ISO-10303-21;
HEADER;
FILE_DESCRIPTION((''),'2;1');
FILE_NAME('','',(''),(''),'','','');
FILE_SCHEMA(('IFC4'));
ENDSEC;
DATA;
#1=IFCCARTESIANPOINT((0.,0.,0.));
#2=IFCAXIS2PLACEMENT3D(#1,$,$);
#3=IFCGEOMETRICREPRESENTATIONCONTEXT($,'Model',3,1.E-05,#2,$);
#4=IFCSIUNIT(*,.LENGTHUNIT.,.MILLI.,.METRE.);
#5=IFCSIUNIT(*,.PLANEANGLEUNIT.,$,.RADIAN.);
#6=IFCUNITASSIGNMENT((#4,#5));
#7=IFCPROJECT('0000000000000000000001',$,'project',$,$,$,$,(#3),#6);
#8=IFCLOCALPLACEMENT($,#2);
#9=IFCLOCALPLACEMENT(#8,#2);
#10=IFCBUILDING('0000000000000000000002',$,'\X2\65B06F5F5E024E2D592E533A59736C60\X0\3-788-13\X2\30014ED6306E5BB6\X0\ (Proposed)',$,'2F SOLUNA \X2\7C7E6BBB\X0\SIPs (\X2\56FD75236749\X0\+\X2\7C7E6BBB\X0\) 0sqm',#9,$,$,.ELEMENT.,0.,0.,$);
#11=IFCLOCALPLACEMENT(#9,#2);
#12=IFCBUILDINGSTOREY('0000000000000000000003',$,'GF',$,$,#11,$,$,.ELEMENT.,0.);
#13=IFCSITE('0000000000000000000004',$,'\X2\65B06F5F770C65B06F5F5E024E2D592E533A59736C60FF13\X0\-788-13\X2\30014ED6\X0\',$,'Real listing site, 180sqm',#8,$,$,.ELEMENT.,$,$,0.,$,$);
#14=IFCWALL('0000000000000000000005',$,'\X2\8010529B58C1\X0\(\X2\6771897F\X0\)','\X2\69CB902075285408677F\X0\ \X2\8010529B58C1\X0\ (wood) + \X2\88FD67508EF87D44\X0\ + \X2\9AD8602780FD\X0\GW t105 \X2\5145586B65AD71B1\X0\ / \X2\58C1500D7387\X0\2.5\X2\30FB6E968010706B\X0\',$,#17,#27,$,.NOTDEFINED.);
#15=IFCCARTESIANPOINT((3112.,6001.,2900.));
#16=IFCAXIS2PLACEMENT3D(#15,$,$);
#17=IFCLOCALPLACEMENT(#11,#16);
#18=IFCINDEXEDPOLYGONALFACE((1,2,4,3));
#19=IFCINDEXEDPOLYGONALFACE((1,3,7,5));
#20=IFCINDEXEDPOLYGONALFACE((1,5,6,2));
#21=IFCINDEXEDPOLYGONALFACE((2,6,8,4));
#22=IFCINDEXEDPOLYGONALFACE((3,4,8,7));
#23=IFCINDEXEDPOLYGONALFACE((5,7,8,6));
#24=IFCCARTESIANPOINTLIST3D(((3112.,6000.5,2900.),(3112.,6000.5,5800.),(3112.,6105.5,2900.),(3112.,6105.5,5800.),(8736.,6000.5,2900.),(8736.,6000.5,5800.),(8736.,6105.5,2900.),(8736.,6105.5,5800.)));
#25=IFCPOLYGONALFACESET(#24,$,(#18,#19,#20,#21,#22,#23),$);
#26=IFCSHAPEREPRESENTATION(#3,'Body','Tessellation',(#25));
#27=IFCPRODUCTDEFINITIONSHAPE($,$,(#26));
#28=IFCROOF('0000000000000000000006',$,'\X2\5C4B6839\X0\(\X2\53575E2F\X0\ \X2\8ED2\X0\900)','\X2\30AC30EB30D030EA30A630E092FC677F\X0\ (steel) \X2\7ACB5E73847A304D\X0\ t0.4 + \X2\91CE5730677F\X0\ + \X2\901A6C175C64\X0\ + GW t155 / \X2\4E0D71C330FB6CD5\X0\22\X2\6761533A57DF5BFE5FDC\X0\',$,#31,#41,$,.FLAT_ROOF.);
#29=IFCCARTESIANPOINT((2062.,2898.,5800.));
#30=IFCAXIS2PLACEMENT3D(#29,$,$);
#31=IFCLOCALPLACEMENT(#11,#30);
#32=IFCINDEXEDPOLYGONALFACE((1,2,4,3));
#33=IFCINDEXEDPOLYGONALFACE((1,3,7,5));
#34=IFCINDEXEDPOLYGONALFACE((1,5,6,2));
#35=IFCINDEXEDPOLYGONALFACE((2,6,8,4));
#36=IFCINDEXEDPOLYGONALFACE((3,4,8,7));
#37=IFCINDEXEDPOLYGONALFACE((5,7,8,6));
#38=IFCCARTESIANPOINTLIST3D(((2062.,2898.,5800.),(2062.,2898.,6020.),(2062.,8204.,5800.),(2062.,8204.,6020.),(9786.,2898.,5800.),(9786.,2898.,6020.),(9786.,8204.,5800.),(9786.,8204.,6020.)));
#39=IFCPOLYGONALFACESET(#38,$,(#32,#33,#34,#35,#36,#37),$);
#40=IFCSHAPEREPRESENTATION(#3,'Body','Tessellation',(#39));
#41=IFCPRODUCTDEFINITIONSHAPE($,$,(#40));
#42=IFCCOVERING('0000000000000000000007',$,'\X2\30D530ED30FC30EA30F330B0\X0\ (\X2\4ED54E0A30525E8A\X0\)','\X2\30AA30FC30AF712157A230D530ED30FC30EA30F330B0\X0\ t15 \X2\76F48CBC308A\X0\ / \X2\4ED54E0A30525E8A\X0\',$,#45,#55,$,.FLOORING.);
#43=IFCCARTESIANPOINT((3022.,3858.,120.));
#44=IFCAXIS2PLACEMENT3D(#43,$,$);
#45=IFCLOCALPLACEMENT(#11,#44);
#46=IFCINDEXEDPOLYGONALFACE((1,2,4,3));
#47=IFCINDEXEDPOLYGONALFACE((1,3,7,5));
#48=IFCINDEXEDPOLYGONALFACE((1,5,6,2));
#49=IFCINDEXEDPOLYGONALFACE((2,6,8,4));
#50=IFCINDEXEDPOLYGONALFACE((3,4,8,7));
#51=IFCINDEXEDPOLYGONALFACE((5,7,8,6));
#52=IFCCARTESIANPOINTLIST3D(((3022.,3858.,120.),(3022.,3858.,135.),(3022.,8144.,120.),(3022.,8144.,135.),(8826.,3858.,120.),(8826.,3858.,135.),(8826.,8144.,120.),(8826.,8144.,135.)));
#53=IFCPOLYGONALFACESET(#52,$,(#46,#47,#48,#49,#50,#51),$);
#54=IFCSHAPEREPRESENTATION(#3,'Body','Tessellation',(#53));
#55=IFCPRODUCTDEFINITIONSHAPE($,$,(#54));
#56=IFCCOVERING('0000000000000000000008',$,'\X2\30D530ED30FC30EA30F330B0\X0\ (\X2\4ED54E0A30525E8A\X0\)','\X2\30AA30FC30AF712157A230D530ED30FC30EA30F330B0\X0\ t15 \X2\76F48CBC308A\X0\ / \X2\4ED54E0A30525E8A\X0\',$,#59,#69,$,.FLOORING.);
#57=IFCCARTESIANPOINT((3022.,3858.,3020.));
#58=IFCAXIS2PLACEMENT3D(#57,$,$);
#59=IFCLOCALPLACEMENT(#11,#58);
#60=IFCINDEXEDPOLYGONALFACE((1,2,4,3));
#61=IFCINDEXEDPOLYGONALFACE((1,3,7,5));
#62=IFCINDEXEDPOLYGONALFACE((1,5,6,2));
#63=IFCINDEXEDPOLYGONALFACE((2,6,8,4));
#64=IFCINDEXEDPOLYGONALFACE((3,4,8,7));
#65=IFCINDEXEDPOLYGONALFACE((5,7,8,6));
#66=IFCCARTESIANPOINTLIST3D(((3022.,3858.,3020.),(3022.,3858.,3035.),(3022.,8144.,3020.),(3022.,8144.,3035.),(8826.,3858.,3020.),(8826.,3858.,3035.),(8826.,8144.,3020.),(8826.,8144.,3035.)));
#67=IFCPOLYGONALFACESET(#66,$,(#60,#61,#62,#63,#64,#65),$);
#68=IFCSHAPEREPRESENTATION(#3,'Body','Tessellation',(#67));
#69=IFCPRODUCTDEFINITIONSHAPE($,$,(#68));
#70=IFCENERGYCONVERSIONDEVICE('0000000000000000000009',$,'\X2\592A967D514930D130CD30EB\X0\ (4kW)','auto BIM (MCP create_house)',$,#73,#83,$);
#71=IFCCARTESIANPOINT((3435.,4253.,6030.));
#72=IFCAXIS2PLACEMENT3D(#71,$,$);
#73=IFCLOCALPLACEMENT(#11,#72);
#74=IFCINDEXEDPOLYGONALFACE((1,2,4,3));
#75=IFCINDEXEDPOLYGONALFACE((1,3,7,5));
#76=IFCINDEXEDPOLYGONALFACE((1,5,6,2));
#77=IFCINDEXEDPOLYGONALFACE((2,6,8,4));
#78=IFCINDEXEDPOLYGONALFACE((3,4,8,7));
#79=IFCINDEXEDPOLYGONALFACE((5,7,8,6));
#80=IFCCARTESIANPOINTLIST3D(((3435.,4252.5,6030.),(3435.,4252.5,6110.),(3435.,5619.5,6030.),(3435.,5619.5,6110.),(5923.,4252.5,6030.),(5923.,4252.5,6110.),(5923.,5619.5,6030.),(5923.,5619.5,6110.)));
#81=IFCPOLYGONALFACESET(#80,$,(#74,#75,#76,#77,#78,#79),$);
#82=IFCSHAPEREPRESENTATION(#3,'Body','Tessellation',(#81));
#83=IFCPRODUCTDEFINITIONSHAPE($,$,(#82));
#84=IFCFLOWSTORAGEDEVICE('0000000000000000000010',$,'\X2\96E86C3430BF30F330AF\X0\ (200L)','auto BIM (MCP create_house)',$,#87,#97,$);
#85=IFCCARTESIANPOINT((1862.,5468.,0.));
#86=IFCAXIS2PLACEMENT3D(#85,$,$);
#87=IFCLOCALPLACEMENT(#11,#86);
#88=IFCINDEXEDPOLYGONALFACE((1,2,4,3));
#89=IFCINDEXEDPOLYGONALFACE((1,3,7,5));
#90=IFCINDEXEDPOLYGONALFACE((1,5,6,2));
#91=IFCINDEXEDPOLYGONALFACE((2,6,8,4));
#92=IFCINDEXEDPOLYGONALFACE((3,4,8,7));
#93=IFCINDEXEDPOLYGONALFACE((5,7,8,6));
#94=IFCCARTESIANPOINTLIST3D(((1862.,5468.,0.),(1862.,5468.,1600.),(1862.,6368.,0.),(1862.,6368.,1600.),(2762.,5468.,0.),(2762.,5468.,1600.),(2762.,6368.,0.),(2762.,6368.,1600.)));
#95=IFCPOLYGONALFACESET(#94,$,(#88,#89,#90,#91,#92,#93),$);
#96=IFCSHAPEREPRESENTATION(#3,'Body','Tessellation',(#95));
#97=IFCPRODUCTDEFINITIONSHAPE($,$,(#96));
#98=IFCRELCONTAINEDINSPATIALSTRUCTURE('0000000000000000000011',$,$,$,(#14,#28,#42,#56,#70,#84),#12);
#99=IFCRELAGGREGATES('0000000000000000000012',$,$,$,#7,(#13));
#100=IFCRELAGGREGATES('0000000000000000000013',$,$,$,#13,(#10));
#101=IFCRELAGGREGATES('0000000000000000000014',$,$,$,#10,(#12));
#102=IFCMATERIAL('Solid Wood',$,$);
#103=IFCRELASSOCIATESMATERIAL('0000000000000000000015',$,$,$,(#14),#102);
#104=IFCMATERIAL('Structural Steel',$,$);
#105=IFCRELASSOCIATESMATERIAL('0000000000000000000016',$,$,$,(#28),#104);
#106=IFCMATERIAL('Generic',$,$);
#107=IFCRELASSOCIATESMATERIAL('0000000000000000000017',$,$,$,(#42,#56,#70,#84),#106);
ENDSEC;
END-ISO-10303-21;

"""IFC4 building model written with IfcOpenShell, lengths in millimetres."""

from ifc_helpers import new_model, si_unit, frame, frame_2d, origin, place, context, project, spatial, rectangle, extrude, material, element, save


model = new_model("IFC4")

# Units and contexts
model_context = context("Model", 3, precision=1e-05, world=origin())
ifc_project = project(units=[si_unit("LENGTHUNIT", "METRE", prefix="MILLI"), si_unit("PLANEANGLEUNIT", "RADIAN")], contexts=[model_context])

# Site, building, storey
site_placement = place(None, origin())
site = spatial("IfcSite", under=ifc_project, at=site_placement, Name="新潟県新潟市中央区女池３-788-13、他", ObjectType="Real listing site, 180sqm", CompositionType="ELEMENT", RefElevation=0.0)
building_placement = place(site_placement, origin())
building = spatial("IfcBuilding", under=site, at=building_placement, Name="新潟市中央区女池3-788-13、他の家 (Proposed)", ObjectType="2F SOLUNA 籾殻SIPs (国産杉+籾殻) 0sqm", CompositionType="ELEMENT", ElevationOfRefHeight=0.0, ElevationOfTerrain=0.0)
storey_placement = place(building_placement, origin())
storey = spatial("IfcBuildingStorey", under=building, at=storey_placement, Name="GF", CompositionType="ELEMENT", Elevation=0.0)

# Shared definitions
ifc_material_1 = material(Name="Solid Wood")

# Wall
wall_1_placement = place(storey_placement, frame((3112.0, 6001.0, 2900.0)))
element("IfcWall", 1, at=wall_1_placement, inside=storey, material=ifc_material_1, Name="耐力壁(東西)", Description="構造用合板 耐力壁 (wood) + 製材軸組 + 高性能GW t105 充填断熱 / 壁倍率2.5・準耐火", PredefinedType="NOTDEFINED", context=model_context, shape_type="SweptSolid", body=[
    extrude(rectangle(XDim=5624.0, YDim=105.0, at=frame_2d((2812.0, 52.0))), frame((3112.0, 6001.0, 2900.0)), (0.0, 0.0, 1.0), 2900.0),
])

# Roof
ifc_material_2 = material(Name="Structural Steel")
for number, where, name in (
    (2, (2062.0, 2898.0, 5800.0), "屋根(南帯 軒900)"),
):
    element("IfcRoof", number, at=place(storey_placement, frame(where)), inside=storey, material=ifc_material_2, Name=name, Description="ガルバリウム鋼板 (steel) 立平葺き t0.4 + 野地板 + 通気層 + GW t155 / 不燃・法22条区域対応", PredefinedType="FLAT_ROOF", context=model_context, shape_type="SweptSolid", body=[
        extrude(rectangle(XDim=7724.0, YDim=5306.0, at=frame_2d((3862.0, 2653.0))), frame((2062.0, 2898.0, 5800.0)), (0.0, 0.0, 1.0), 220.0),
    ])

# Coverings
ifc_material_3 = material(Name="Generic")
covering_1_placement = place(storey_placement, frame((3022.0, 3858.0, 120.0)))
element("IfcCovering", 3, at=covering_1_placement, inside=storey, material=ifc_material_3, Name="フローリング (仕上げ床)", Description="オーク無垢フローリング t15 直貼り / 仕上げ床", PredefinedType="FLOORING", context=model_context, shape_type="SweptSolid", body=[
    extrude(rectangle(XDim=5804.0, YDim=4286.0, at=frame_2d((2902.0, 2143.0))), frame((3022.0, 3858.0, 120.0)), (0.0, 0.0, 1.0), 15.0),
])
covering_2_placement = place(storey_placement, frame((3022.0, 3858.0, 3020.0)))
element("IfcCovering", 4, at=covering_2_placement, inside=storey, material=ifc_material_3, Name="フローリング (仕上げ床)", Description="オーク無垢フローリング t15 直貼り / 仕上げ床", PredefinedType="FLOORING", context=model_context, shape_type="SweptSolid", body=[
    extrude(rectangle(XDim=5804.0, YDim=4286.0, at=frame_2d((2902.0, 2143.0))), frame((3022.0, 3858.0, 3020.0)), (0.0, 0.0, 1.0), 15.0),
])

# Energy conversion device
energy_conversion_device_placement = place(storey_placement, frame((3435.0, 4253.0, 6030.0)))
element("IfcEnergyConversionDevice", 5, at=energy_conversion_device_placement, inside=storey, material=ifc_material_3, Name="太陽光パネル (4kW)", Description="auto BIM (MCP create_house)", context=model_context, shape_type="SweptSolid", body=[
    extrude(rectangle(XDim=2488.0, YDim=1367.0, at=frame_2d((1244.0, 683.0))), frame((3435.0, 4253.0, 6030.0)), (0.0, 0.0, 1.0), 80.0),
])

# Flow storage device
flow_storage_device_placement = place(storey_placement, frame((1862.0, 5468.0, 0.0)))
element("IfcFlowStorageDevice", 6, at=flow_storage_device_placement, inside=storey, material=ifc_material_3, Name="雨水タンク (200L)", Description="auto BIM (MCP create_house)", context=model_context, shape_type="SweptSolid", body=[
    extrude(rectangle(XDim=900.0, YDim=900.0, at=frame_2d((450.0, 450.0))), frame((1862.0, 5468.0, 0.0)), (0.0, 0.0, 1.0), 1600.0),
])

save(model, "model.ifc")
